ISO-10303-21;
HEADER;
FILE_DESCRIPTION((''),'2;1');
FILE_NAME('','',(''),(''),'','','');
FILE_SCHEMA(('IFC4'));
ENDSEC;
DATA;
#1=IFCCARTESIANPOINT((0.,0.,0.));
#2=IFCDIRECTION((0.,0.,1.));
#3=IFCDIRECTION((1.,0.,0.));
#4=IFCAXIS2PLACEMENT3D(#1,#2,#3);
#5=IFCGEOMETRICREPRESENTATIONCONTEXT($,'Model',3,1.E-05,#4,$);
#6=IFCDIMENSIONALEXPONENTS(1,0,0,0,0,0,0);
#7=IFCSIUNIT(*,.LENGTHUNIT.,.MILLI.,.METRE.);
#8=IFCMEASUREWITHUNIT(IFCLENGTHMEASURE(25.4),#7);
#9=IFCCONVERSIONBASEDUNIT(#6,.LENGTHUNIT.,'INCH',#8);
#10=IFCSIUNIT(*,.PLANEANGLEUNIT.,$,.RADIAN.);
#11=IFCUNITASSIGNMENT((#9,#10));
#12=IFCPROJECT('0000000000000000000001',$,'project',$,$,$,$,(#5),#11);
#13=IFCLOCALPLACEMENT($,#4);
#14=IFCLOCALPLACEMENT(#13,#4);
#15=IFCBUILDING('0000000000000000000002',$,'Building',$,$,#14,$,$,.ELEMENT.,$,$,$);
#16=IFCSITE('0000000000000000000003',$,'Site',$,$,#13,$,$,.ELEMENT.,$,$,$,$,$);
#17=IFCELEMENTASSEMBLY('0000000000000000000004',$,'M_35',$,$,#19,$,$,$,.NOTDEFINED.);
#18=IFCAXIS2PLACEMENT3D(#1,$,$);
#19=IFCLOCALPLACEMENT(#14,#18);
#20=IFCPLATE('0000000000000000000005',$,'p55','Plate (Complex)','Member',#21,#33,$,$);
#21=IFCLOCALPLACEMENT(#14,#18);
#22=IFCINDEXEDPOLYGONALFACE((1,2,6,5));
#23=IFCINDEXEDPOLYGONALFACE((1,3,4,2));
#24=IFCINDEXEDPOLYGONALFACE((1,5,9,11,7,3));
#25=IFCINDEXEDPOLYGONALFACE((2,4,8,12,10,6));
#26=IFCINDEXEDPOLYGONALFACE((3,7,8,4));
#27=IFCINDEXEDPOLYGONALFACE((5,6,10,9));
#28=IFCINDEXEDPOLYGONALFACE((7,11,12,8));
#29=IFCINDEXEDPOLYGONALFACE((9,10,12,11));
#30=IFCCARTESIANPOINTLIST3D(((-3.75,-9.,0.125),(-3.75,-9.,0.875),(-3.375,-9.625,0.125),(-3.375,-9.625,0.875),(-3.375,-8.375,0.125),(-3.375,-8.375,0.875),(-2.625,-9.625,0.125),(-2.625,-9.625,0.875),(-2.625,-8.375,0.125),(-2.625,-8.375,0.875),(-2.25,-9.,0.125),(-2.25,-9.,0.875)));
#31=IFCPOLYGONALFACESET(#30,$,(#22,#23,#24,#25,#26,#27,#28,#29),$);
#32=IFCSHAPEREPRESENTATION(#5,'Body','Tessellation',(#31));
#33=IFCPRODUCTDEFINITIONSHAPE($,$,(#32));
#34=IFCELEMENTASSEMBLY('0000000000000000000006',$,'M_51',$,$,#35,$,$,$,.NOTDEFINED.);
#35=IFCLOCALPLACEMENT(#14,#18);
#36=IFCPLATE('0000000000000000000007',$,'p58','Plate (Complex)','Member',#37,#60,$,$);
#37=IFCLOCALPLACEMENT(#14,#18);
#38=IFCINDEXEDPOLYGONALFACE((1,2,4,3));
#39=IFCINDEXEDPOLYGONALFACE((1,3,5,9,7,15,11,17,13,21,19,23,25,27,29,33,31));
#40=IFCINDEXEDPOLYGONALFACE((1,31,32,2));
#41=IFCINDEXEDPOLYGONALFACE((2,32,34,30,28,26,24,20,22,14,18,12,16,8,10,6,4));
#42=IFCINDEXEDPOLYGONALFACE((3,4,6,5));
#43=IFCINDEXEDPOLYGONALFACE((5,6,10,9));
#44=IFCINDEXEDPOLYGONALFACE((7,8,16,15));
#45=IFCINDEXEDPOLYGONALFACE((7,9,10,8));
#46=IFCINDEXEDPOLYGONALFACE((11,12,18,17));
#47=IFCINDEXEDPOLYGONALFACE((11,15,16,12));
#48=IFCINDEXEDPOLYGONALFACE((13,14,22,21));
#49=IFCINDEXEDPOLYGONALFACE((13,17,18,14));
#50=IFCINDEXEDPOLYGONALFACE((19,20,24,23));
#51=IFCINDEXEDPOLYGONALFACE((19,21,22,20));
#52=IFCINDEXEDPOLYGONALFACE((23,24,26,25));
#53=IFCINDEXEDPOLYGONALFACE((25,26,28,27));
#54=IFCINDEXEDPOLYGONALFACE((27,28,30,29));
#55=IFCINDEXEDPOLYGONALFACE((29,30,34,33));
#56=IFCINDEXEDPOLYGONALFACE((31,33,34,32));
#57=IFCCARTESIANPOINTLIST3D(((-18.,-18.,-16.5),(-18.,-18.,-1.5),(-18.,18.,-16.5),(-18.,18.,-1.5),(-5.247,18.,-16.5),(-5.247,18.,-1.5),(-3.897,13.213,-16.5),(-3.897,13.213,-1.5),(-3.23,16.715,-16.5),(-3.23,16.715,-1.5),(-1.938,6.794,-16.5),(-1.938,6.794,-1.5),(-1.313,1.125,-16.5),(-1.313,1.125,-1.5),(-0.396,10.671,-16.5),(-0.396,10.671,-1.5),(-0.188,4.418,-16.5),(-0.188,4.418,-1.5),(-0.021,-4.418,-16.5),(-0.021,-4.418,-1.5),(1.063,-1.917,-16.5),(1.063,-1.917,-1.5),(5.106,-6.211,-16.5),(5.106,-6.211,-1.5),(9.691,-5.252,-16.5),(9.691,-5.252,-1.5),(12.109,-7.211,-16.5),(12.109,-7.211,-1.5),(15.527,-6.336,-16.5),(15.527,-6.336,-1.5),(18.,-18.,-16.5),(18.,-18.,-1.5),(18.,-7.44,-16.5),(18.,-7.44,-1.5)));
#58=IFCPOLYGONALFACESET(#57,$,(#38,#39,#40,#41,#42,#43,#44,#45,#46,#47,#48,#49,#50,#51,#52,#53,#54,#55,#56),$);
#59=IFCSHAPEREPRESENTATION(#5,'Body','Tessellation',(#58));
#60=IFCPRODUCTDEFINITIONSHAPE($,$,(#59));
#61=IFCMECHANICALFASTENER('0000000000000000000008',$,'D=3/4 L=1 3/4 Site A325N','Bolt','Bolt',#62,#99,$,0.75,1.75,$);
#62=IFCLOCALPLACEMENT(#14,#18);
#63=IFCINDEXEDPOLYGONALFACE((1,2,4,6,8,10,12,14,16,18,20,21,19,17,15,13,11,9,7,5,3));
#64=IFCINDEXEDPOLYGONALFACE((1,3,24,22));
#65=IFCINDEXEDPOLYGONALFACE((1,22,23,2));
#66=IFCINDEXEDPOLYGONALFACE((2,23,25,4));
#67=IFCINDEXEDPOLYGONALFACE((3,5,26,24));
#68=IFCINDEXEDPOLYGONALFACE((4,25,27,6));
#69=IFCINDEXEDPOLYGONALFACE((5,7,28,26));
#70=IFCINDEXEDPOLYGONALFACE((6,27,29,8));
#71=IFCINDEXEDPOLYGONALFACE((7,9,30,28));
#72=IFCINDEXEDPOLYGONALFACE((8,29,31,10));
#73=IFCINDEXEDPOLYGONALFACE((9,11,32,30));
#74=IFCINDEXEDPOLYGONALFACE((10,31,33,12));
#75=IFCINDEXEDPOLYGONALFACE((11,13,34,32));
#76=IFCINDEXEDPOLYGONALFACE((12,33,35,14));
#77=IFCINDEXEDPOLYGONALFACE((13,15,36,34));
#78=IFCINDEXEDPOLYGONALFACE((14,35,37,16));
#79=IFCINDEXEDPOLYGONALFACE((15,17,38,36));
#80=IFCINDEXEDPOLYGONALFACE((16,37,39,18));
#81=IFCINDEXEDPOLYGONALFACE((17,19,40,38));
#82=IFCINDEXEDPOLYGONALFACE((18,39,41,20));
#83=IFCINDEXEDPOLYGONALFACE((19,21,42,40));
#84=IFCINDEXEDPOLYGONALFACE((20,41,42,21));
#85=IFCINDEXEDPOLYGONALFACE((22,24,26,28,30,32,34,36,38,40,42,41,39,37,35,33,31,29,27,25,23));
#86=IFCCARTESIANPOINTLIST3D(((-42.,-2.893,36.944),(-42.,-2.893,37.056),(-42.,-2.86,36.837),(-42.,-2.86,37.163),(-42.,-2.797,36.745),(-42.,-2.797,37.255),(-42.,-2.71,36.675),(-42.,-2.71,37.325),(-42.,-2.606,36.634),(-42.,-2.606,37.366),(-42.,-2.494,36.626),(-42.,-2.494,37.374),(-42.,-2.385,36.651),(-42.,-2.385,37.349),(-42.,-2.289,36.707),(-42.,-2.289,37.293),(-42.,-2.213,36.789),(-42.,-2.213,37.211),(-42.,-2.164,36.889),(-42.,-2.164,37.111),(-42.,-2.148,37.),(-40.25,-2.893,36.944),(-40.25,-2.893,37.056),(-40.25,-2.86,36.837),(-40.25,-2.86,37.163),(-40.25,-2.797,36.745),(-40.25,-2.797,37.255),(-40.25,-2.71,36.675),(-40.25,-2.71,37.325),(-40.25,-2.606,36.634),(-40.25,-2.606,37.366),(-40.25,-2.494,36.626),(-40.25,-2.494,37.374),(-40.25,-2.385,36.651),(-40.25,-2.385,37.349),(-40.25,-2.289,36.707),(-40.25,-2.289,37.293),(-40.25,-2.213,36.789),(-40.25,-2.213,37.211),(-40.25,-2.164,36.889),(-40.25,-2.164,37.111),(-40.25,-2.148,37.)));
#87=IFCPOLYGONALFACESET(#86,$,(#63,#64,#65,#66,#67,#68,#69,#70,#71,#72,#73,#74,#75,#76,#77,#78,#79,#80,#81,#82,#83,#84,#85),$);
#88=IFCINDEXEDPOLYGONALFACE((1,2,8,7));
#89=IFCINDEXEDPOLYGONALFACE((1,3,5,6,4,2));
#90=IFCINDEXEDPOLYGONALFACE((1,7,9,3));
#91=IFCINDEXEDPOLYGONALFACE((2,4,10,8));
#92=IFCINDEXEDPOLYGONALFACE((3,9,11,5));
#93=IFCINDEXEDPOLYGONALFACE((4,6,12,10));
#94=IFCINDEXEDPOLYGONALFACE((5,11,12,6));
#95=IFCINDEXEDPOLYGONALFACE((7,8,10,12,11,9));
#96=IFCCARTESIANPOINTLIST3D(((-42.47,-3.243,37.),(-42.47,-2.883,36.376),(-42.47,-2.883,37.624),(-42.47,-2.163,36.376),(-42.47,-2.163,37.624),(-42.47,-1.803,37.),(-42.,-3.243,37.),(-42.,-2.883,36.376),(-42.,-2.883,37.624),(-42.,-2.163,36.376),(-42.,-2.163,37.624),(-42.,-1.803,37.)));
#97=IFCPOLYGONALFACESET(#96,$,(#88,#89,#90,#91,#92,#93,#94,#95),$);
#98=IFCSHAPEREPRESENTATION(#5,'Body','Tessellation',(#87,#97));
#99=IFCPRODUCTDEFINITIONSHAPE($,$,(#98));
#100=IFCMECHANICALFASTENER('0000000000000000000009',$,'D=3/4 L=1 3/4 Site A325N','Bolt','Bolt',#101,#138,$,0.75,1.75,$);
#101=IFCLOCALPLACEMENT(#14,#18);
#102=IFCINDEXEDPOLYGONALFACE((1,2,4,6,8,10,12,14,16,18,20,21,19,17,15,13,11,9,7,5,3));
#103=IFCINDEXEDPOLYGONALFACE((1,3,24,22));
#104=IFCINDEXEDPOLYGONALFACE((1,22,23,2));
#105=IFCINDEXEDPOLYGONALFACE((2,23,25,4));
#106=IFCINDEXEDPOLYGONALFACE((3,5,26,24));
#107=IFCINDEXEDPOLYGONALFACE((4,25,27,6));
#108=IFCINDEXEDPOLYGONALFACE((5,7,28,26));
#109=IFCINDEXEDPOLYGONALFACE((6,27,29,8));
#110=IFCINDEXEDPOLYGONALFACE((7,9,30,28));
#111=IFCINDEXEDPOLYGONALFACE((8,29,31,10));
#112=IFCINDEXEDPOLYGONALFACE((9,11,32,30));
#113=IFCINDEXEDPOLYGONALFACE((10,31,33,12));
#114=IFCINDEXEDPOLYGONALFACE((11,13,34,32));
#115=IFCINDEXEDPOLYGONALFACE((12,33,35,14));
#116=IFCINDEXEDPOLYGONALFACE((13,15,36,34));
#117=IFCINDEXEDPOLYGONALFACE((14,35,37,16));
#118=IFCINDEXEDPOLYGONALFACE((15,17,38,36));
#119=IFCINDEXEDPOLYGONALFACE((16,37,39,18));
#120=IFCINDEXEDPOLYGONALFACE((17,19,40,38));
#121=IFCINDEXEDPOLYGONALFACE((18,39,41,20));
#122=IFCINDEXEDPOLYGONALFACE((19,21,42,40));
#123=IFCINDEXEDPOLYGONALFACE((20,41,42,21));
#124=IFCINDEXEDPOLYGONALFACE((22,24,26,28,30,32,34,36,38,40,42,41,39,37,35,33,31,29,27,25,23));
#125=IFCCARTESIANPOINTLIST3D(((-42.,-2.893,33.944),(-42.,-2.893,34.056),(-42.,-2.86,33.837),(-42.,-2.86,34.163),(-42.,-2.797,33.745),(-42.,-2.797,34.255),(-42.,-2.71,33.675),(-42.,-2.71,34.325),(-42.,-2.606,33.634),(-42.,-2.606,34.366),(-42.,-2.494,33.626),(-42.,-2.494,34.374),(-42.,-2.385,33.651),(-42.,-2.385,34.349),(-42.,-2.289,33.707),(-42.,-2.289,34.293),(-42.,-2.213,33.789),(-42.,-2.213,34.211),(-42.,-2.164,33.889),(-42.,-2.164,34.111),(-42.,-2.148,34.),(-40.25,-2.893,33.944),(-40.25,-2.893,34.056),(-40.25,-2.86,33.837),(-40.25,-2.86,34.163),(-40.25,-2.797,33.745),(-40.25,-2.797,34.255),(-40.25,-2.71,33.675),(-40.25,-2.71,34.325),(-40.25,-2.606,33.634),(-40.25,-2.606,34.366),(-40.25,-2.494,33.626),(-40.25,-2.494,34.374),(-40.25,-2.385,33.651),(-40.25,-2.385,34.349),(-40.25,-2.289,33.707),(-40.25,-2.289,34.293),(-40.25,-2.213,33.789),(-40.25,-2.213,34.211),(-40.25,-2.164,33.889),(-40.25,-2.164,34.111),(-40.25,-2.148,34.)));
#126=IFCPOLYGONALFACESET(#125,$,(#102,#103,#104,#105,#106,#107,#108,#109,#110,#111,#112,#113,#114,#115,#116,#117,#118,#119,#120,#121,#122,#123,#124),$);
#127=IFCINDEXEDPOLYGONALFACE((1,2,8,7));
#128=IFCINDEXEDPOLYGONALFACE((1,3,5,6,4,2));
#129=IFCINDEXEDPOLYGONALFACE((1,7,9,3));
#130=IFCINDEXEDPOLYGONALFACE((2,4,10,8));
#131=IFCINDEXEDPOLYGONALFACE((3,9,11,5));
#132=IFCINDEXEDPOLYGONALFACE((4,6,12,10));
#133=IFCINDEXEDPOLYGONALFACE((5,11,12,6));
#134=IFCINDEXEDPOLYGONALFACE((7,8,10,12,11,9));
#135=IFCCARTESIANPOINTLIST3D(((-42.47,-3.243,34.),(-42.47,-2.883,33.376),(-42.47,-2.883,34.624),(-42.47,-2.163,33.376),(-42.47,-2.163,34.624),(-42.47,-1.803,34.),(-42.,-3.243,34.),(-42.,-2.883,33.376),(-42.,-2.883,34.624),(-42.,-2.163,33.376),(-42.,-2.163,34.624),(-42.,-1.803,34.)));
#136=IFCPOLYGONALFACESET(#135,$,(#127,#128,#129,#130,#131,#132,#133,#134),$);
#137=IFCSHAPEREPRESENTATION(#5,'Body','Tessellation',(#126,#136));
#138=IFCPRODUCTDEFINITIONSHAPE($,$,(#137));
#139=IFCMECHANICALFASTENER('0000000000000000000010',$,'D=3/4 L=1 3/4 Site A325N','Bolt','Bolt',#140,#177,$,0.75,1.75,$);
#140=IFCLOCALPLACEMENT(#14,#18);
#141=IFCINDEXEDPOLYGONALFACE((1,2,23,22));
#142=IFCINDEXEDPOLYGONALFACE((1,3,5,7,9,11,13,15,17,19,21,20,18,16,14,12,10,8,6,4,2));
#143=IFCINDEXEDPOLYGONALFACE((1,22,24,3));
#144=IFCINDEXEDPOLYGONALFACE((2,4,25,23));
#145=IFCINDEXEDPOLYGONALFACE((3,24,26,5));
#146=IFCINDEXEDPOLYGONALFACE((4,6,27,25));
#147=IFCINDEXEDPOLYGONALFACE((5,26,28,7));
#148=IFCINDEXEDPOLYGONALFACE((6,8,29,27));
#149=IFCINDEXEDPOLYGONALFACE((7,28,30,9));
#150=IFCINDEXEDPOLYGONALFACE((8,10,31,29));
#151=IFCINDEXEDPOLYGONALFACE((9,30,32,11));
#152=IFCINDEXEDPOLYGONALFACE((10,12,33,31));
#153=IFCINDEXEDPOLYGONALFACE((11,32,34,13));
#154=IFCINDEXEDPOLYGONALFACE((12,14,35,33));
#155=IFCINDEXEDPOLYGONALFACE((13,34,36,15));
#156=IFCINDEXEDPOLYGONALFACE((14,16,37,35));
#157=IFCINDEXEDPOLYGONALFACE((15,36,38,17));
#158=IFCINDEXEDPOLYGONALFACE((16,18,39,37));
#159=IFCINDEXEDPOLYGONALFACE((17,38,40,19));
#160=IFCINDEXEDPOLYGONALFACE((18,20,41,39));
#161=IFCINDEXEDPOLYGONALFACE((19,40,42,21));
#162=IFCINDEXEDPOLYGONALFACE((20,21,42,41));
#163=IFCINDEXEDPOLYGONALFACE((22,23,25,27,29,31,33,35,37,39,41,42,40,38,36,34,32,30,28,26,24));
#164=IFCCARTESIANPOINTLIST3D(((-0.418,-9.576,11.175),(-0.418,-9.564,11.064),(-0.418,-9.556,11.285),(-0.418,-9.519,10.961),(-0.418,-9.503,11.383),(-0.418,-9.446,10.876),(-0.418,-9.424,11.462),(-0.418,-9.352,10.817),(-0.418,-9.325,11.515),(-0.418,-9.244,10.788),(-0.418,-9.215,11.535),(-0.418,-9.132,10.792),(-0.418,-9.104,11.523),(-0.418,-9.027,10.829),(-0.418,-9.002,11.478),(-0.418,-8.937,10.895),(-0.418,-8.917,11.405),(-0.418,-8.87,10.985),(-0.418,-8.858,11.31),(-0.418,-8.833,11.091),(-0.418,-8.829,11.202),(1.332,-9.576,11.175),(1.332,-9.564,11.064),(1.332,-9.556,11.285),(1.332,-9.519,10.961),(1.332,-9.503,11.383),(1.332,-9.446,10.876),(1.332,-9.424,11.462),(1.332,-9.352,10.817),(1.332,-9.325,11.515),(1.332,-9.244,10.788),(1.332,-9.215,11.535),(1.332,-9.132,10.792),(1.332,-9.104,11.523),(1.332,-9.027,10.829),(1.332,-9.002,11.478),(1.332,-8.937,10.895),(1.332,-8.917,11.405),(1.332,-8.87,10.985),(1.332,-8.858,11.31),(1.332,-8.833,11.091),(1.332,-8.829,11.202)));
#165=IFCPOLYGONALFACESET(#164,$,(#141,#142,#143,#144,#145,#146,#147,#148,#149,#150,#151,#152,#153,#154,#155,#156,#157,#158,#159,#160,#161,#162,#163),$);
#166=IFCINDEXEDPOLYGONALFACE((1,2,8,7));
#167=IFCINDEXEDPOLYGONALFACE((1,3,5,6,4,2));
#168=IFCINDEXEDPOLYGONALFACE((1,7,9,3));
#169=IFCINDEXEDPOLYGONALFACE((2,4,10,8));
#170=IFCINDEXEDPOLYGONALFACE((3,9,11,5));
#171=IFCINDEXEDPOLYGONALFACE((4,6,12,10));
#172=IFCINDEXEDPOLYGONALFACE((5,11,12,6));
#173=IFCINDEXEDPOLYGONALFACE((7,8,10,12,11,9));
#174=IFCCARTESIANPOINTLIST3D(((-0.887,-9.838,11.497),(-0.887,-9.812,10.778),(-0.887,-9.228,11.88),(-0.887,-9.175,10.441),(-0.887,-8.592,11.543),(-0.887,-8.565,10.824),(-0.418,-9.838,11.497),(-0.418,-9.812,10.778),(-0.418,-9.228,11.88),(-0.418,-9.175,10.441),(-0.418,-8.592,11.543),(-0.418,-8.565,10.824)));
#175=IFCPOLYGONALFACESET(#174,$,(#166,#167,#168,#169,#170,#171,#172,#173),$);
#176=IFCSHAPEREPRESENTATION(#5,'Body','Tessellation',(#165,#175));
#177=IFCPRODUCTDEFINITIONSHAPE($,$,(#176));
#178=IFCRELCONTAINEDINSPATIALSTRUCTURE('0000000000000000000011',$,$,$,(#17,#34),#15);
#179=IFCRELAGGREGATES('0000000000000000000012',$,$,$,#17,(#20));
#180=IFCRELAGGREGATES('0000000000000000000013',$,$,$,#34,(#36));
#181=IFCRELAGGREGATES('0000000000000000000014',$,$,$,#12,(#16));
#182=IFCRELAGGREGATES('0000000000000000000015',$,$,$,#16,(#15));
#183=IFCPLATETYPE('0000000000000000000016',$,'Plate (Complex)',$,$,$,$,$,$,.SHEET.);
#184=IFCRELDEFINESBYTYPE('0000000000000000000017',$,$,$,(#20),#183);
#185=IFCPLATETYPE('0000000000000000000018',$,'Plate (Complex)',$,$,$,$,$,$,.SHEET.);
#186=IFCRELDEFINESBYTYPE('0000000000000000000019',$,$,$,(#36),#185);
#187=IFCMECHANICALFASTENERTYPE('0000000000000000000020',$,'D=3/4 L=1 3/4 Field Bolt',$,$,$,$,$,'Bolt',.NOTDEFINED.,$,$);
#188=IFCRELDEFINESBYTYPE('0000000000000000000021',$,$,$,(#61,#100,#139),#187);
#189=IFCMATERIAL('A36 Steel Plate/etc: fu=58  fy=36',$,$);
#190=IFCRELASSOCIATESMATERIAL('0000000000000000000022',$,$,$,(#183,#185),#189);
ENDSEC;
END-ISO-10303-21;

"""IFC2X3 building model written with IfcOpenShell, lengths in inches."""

from ifc_helpers import new_model, entity, si_unit, converted_unit, frame, origin_with_axes, origin_2d_with_axis, place, context, project, spatial, polyline, circle, outline, extrude, source, transform, mapped, material, type_object, type_shapes, element, aggregate, save


model = new_model("IFC2X3")

# Units and contexts
model_context = context("Model", 3, precision=1e-05, world=origin_with_axes())
ifc_project = project(units=[converted_unit("LENGTHUNIT", "INCH", entity("IfcLengthMeasure", 25.4), si_unit("LENGTHUNIT", "METRE", prefix="MILLI"), dimensions=[1, 0, 0, 0, 0, 0, 0]), si_unit("PLANEANGLEUNIT", "RADIAN")], contexts=[model_context])

# Site, building
site_placement = place(None, origin_with_axes())
site = spatial("IfcSite", under=ifc_project, at=site_placement, Name="Site", CompositionType="ELEMENT")
building_placement = place(site_placement, origin_with_axes())
building = spatial("IfcBuilding", under=site, at=building_placement, Name="Building", CompositionType="ELEMENT")

# Element assembly, plate
assembly_1_placement = place(building_placement, frame((-3.0, -9.0, -22.668), z_axis=(0.0, -1.0, 0.0), x_axis=(0.0, 0.0, 1.0)))
assembly_1 = element("IfcElementAssembly", 1, at=assembly_1_placement, inside=building, Name="M_35", PredefinedType="NOTDEFINED")
ifc_material = material(Name="A36 Steel Plate/etc: fu=58  fy=36")
plate_type_1 = type_object("IfcPlateType", Name="Plate (Complex)", PredefinedType="SHEET", material=ifc_material)
shared_shape_1 = source(origin_with_axes(), model_context, "Body", "SweptSolid", [
    extrude(outline(polyline([(0.0, -1.125), (-0.625, -1.5), (-1.25, -1.125), (-1.25, -0.375), (-0.625, 0.0), (0.0, -0.375), (0.0, -1.125)])), frame((-0.375, 0.0, 0.0), z_axis=(1.0, 0.0, 0.0), x_axis=(0.0, 1.0, 0.0)), (0.0, 0.0, 1.0), 0.75),
])
type_shapes(plate_type_1, [shared_shape_1])
plate_1_placement = place(assembly_1_placement, frame((23.168, 0.75, -0.625), z_axis=(0.0, 1.0, 0.0), x_axis=(1.0, 0.0, 0.0)))
plate_1 = element("IfcPlate", 2, at=plate_1_placement, type_object=plate_type_1, Name="p55", Description="Plate (Complex)", ObjectType="Member", context=model_context, shape_type="MappedRepresentation", body=[
    mapped(shared_shape_1, transform((0.0, 0.0, 0.0), scale=1.0)),
])
aggregate(assembly_1, [plate_1])

# Element assembly, plate
assembly_2_placement = place(building_placement, frame((-18.0, -18.0, -1.5), z_axis=(0.0, -1.0, 0.0), x_axis=(0.0, 0.0, 1.0)))
assembly_2 = element("IfcElementAssembly", 3, at=assembly_2_placement, inside=building, Name="M_51", PredefinedType="NOTDEFINED")
plate_type_2 = type_object("IfcPlateType", Name="Plate (Complex)", PredefinedType="SHEET", material=ifc_material)
shared_shape_2 = source(origin_with_axes(), model_context, "Body", "SweptSolid", [
    extrude(outline(polyline([(-33.527, -11.664), (-36.0, -10.56), (-36.0, 0.0), (0.0, 0.0), (0.0, -36.0), (-12.753, -36.0), (-14.77, -34.715), (-14.103, -31.213), (-17.604, -28.671), (-16.062, -24.794), (-17.812, -22.418), (-16.687, -19.125), (-19.063, -16.083), (-17.979, -13.582), (-23.106, -11.789), (-27.691, -12.748), (-30.109, -10.789), (-33.527, -11.664)])), frame((-7.5, 0.0, 0.0), z_axis=(1.0, 0.0, 0.0), x_axis=(0.0, 1.0, 0.0)), (0.0, 0.0, 1.0), 15.0),
])
type_shapes(plate_type_2, [shared_shape_2])
plate_2_placement = place(assembly_2_placement, frame((-7.5, 0.0, 0.0), z_axis=(0.0, 0.0, 1.0), x_axis=(1.0, 0.0, 0.0)))
plate_2 = element("IfcPlate", 4, at=plate_2_placement, type_object=plate_type_2, Name="p58", Description="Plate (Complex)", ObjectType="Member", context=model_context, shape_type="MappedRepresentation", body=[
    mapped(shared_shape_2, transform((0.0, 0.0, 0.0), scale=1.0)),
])
aggregate(assembly_2, [plate_2])

# Mechanical fasteners
mechanical_fastener_type_1 = type_object("IfcMechanicalFastenerType", Name="D=3/4 L=1 3/4 Field Bolt", ElementType="Bolt")
shared_shape_3 = source(origin_with_axes(), model_context, "Body", "SweptSolid", [
    extrude(circle(Radius=0.375, at=origin_2d_with_axis()), frame((0.0, 0.0, 0.0), z_axis=(1.0, 0.0, 0.0), x_axis=(0.0, 1.0, 0.0)), (0.0, 0.0, 1.0), 1.75),
    extrude(outline(polyline([(-0.72, 0.0), (-0.36, 0.624), (0.36, 0.624), (0.72, 0.0), (0.36, -0.624), (-0.36, -0.624), (-0.72, 0.0)])), frame((0.0, 0.0, 0.0), z_axis=(1.0, 0.0, 0.0), x_axis=(0.0, 1.0, 0.0)), (0.0, 0.0, -1.0), 0.47),
])
type_shapes(mechanical_fastener_type_1, [shared_shape_3])
placement_1 = place(building_placement, frame((-42.0, 0.0, 43.0), z_axis=(0.0, 0.0, 1.0), x_axis=(0.0, -1.0, 0.0)))
placement_2 = place(placement_1, frame((2.523, 0.0, -9.0), z_axis=(0.0, 0.0, 1.0), x_axis=(0.0, 1.0, 0.0)))
for number, where, z_axis, x_axis, name in (
    (5, (0.0, 0.0, 3.0), (0.0, 0.0, 1.0), (1.0, 0.0, 0.0), "D=3/4 L=1 3/4 Site A325N"),
    (6, (0.0, 0.0, 0.0), (0.0, 0.0, 1.0), (1.0, 0.0, 0.0), "D=3/4 L=1 3/4 Site A325N"),
):
    element("IfcMechanicalFastener", number, at=place(placement_2, frame(where, z_axis=z_axis, x_axis=x_axis)), type_object=mechanical_fastener_type_1, Name=name, Description="Bolt", ObjectType="Bolt", NominalDiameter=0.75, NominalLength=1.75, context=model_context, shape_type="MappedRepresentation", body=[
        mapped(shared_shape_3, transform((0.0, 0.0, 0.0), scale=1.0)),
    ])
placement_3 = place(building_placement, frame((-0.303, -6.355, 7.978), z_axis=(0.0, 0.470284, 0.882515), x_axis=(0.0, -0.882515, 0.470284)))
placement_4 = place(placement_3, frame((4.009, -0.115, 1.47), z_axis=(0.002713, 0.0, 0.999996), x_axis=(0.0, 1.0, 0.0)))
for number, where, z_axis, x_axis, name in (
    (7, (0.0, 0.0, 0.0), (0.0, 0.0, 1.0), (1.0, 0.0, 0.0), "D=3/4 L=1 3/4 Site A325N"),
):
    element("IfcMechanicalFastener", number, at=place(placement_4, frame(where, z_axis=z_axis, x_axis=x_axis)), type_object=mechanical_fastener_type_1, Name=name, Description="Bolt", ObjectType="Bolt", NominalDiameter=0.75, NominalLength=1.75, context=model_context, shape_type="MappedRepresentation", body=[
        mapped(shared_shape_3, transform((0.0, 0.0, 0.0), scale=1.0)),
    ])

save(model, "model.ifc")
